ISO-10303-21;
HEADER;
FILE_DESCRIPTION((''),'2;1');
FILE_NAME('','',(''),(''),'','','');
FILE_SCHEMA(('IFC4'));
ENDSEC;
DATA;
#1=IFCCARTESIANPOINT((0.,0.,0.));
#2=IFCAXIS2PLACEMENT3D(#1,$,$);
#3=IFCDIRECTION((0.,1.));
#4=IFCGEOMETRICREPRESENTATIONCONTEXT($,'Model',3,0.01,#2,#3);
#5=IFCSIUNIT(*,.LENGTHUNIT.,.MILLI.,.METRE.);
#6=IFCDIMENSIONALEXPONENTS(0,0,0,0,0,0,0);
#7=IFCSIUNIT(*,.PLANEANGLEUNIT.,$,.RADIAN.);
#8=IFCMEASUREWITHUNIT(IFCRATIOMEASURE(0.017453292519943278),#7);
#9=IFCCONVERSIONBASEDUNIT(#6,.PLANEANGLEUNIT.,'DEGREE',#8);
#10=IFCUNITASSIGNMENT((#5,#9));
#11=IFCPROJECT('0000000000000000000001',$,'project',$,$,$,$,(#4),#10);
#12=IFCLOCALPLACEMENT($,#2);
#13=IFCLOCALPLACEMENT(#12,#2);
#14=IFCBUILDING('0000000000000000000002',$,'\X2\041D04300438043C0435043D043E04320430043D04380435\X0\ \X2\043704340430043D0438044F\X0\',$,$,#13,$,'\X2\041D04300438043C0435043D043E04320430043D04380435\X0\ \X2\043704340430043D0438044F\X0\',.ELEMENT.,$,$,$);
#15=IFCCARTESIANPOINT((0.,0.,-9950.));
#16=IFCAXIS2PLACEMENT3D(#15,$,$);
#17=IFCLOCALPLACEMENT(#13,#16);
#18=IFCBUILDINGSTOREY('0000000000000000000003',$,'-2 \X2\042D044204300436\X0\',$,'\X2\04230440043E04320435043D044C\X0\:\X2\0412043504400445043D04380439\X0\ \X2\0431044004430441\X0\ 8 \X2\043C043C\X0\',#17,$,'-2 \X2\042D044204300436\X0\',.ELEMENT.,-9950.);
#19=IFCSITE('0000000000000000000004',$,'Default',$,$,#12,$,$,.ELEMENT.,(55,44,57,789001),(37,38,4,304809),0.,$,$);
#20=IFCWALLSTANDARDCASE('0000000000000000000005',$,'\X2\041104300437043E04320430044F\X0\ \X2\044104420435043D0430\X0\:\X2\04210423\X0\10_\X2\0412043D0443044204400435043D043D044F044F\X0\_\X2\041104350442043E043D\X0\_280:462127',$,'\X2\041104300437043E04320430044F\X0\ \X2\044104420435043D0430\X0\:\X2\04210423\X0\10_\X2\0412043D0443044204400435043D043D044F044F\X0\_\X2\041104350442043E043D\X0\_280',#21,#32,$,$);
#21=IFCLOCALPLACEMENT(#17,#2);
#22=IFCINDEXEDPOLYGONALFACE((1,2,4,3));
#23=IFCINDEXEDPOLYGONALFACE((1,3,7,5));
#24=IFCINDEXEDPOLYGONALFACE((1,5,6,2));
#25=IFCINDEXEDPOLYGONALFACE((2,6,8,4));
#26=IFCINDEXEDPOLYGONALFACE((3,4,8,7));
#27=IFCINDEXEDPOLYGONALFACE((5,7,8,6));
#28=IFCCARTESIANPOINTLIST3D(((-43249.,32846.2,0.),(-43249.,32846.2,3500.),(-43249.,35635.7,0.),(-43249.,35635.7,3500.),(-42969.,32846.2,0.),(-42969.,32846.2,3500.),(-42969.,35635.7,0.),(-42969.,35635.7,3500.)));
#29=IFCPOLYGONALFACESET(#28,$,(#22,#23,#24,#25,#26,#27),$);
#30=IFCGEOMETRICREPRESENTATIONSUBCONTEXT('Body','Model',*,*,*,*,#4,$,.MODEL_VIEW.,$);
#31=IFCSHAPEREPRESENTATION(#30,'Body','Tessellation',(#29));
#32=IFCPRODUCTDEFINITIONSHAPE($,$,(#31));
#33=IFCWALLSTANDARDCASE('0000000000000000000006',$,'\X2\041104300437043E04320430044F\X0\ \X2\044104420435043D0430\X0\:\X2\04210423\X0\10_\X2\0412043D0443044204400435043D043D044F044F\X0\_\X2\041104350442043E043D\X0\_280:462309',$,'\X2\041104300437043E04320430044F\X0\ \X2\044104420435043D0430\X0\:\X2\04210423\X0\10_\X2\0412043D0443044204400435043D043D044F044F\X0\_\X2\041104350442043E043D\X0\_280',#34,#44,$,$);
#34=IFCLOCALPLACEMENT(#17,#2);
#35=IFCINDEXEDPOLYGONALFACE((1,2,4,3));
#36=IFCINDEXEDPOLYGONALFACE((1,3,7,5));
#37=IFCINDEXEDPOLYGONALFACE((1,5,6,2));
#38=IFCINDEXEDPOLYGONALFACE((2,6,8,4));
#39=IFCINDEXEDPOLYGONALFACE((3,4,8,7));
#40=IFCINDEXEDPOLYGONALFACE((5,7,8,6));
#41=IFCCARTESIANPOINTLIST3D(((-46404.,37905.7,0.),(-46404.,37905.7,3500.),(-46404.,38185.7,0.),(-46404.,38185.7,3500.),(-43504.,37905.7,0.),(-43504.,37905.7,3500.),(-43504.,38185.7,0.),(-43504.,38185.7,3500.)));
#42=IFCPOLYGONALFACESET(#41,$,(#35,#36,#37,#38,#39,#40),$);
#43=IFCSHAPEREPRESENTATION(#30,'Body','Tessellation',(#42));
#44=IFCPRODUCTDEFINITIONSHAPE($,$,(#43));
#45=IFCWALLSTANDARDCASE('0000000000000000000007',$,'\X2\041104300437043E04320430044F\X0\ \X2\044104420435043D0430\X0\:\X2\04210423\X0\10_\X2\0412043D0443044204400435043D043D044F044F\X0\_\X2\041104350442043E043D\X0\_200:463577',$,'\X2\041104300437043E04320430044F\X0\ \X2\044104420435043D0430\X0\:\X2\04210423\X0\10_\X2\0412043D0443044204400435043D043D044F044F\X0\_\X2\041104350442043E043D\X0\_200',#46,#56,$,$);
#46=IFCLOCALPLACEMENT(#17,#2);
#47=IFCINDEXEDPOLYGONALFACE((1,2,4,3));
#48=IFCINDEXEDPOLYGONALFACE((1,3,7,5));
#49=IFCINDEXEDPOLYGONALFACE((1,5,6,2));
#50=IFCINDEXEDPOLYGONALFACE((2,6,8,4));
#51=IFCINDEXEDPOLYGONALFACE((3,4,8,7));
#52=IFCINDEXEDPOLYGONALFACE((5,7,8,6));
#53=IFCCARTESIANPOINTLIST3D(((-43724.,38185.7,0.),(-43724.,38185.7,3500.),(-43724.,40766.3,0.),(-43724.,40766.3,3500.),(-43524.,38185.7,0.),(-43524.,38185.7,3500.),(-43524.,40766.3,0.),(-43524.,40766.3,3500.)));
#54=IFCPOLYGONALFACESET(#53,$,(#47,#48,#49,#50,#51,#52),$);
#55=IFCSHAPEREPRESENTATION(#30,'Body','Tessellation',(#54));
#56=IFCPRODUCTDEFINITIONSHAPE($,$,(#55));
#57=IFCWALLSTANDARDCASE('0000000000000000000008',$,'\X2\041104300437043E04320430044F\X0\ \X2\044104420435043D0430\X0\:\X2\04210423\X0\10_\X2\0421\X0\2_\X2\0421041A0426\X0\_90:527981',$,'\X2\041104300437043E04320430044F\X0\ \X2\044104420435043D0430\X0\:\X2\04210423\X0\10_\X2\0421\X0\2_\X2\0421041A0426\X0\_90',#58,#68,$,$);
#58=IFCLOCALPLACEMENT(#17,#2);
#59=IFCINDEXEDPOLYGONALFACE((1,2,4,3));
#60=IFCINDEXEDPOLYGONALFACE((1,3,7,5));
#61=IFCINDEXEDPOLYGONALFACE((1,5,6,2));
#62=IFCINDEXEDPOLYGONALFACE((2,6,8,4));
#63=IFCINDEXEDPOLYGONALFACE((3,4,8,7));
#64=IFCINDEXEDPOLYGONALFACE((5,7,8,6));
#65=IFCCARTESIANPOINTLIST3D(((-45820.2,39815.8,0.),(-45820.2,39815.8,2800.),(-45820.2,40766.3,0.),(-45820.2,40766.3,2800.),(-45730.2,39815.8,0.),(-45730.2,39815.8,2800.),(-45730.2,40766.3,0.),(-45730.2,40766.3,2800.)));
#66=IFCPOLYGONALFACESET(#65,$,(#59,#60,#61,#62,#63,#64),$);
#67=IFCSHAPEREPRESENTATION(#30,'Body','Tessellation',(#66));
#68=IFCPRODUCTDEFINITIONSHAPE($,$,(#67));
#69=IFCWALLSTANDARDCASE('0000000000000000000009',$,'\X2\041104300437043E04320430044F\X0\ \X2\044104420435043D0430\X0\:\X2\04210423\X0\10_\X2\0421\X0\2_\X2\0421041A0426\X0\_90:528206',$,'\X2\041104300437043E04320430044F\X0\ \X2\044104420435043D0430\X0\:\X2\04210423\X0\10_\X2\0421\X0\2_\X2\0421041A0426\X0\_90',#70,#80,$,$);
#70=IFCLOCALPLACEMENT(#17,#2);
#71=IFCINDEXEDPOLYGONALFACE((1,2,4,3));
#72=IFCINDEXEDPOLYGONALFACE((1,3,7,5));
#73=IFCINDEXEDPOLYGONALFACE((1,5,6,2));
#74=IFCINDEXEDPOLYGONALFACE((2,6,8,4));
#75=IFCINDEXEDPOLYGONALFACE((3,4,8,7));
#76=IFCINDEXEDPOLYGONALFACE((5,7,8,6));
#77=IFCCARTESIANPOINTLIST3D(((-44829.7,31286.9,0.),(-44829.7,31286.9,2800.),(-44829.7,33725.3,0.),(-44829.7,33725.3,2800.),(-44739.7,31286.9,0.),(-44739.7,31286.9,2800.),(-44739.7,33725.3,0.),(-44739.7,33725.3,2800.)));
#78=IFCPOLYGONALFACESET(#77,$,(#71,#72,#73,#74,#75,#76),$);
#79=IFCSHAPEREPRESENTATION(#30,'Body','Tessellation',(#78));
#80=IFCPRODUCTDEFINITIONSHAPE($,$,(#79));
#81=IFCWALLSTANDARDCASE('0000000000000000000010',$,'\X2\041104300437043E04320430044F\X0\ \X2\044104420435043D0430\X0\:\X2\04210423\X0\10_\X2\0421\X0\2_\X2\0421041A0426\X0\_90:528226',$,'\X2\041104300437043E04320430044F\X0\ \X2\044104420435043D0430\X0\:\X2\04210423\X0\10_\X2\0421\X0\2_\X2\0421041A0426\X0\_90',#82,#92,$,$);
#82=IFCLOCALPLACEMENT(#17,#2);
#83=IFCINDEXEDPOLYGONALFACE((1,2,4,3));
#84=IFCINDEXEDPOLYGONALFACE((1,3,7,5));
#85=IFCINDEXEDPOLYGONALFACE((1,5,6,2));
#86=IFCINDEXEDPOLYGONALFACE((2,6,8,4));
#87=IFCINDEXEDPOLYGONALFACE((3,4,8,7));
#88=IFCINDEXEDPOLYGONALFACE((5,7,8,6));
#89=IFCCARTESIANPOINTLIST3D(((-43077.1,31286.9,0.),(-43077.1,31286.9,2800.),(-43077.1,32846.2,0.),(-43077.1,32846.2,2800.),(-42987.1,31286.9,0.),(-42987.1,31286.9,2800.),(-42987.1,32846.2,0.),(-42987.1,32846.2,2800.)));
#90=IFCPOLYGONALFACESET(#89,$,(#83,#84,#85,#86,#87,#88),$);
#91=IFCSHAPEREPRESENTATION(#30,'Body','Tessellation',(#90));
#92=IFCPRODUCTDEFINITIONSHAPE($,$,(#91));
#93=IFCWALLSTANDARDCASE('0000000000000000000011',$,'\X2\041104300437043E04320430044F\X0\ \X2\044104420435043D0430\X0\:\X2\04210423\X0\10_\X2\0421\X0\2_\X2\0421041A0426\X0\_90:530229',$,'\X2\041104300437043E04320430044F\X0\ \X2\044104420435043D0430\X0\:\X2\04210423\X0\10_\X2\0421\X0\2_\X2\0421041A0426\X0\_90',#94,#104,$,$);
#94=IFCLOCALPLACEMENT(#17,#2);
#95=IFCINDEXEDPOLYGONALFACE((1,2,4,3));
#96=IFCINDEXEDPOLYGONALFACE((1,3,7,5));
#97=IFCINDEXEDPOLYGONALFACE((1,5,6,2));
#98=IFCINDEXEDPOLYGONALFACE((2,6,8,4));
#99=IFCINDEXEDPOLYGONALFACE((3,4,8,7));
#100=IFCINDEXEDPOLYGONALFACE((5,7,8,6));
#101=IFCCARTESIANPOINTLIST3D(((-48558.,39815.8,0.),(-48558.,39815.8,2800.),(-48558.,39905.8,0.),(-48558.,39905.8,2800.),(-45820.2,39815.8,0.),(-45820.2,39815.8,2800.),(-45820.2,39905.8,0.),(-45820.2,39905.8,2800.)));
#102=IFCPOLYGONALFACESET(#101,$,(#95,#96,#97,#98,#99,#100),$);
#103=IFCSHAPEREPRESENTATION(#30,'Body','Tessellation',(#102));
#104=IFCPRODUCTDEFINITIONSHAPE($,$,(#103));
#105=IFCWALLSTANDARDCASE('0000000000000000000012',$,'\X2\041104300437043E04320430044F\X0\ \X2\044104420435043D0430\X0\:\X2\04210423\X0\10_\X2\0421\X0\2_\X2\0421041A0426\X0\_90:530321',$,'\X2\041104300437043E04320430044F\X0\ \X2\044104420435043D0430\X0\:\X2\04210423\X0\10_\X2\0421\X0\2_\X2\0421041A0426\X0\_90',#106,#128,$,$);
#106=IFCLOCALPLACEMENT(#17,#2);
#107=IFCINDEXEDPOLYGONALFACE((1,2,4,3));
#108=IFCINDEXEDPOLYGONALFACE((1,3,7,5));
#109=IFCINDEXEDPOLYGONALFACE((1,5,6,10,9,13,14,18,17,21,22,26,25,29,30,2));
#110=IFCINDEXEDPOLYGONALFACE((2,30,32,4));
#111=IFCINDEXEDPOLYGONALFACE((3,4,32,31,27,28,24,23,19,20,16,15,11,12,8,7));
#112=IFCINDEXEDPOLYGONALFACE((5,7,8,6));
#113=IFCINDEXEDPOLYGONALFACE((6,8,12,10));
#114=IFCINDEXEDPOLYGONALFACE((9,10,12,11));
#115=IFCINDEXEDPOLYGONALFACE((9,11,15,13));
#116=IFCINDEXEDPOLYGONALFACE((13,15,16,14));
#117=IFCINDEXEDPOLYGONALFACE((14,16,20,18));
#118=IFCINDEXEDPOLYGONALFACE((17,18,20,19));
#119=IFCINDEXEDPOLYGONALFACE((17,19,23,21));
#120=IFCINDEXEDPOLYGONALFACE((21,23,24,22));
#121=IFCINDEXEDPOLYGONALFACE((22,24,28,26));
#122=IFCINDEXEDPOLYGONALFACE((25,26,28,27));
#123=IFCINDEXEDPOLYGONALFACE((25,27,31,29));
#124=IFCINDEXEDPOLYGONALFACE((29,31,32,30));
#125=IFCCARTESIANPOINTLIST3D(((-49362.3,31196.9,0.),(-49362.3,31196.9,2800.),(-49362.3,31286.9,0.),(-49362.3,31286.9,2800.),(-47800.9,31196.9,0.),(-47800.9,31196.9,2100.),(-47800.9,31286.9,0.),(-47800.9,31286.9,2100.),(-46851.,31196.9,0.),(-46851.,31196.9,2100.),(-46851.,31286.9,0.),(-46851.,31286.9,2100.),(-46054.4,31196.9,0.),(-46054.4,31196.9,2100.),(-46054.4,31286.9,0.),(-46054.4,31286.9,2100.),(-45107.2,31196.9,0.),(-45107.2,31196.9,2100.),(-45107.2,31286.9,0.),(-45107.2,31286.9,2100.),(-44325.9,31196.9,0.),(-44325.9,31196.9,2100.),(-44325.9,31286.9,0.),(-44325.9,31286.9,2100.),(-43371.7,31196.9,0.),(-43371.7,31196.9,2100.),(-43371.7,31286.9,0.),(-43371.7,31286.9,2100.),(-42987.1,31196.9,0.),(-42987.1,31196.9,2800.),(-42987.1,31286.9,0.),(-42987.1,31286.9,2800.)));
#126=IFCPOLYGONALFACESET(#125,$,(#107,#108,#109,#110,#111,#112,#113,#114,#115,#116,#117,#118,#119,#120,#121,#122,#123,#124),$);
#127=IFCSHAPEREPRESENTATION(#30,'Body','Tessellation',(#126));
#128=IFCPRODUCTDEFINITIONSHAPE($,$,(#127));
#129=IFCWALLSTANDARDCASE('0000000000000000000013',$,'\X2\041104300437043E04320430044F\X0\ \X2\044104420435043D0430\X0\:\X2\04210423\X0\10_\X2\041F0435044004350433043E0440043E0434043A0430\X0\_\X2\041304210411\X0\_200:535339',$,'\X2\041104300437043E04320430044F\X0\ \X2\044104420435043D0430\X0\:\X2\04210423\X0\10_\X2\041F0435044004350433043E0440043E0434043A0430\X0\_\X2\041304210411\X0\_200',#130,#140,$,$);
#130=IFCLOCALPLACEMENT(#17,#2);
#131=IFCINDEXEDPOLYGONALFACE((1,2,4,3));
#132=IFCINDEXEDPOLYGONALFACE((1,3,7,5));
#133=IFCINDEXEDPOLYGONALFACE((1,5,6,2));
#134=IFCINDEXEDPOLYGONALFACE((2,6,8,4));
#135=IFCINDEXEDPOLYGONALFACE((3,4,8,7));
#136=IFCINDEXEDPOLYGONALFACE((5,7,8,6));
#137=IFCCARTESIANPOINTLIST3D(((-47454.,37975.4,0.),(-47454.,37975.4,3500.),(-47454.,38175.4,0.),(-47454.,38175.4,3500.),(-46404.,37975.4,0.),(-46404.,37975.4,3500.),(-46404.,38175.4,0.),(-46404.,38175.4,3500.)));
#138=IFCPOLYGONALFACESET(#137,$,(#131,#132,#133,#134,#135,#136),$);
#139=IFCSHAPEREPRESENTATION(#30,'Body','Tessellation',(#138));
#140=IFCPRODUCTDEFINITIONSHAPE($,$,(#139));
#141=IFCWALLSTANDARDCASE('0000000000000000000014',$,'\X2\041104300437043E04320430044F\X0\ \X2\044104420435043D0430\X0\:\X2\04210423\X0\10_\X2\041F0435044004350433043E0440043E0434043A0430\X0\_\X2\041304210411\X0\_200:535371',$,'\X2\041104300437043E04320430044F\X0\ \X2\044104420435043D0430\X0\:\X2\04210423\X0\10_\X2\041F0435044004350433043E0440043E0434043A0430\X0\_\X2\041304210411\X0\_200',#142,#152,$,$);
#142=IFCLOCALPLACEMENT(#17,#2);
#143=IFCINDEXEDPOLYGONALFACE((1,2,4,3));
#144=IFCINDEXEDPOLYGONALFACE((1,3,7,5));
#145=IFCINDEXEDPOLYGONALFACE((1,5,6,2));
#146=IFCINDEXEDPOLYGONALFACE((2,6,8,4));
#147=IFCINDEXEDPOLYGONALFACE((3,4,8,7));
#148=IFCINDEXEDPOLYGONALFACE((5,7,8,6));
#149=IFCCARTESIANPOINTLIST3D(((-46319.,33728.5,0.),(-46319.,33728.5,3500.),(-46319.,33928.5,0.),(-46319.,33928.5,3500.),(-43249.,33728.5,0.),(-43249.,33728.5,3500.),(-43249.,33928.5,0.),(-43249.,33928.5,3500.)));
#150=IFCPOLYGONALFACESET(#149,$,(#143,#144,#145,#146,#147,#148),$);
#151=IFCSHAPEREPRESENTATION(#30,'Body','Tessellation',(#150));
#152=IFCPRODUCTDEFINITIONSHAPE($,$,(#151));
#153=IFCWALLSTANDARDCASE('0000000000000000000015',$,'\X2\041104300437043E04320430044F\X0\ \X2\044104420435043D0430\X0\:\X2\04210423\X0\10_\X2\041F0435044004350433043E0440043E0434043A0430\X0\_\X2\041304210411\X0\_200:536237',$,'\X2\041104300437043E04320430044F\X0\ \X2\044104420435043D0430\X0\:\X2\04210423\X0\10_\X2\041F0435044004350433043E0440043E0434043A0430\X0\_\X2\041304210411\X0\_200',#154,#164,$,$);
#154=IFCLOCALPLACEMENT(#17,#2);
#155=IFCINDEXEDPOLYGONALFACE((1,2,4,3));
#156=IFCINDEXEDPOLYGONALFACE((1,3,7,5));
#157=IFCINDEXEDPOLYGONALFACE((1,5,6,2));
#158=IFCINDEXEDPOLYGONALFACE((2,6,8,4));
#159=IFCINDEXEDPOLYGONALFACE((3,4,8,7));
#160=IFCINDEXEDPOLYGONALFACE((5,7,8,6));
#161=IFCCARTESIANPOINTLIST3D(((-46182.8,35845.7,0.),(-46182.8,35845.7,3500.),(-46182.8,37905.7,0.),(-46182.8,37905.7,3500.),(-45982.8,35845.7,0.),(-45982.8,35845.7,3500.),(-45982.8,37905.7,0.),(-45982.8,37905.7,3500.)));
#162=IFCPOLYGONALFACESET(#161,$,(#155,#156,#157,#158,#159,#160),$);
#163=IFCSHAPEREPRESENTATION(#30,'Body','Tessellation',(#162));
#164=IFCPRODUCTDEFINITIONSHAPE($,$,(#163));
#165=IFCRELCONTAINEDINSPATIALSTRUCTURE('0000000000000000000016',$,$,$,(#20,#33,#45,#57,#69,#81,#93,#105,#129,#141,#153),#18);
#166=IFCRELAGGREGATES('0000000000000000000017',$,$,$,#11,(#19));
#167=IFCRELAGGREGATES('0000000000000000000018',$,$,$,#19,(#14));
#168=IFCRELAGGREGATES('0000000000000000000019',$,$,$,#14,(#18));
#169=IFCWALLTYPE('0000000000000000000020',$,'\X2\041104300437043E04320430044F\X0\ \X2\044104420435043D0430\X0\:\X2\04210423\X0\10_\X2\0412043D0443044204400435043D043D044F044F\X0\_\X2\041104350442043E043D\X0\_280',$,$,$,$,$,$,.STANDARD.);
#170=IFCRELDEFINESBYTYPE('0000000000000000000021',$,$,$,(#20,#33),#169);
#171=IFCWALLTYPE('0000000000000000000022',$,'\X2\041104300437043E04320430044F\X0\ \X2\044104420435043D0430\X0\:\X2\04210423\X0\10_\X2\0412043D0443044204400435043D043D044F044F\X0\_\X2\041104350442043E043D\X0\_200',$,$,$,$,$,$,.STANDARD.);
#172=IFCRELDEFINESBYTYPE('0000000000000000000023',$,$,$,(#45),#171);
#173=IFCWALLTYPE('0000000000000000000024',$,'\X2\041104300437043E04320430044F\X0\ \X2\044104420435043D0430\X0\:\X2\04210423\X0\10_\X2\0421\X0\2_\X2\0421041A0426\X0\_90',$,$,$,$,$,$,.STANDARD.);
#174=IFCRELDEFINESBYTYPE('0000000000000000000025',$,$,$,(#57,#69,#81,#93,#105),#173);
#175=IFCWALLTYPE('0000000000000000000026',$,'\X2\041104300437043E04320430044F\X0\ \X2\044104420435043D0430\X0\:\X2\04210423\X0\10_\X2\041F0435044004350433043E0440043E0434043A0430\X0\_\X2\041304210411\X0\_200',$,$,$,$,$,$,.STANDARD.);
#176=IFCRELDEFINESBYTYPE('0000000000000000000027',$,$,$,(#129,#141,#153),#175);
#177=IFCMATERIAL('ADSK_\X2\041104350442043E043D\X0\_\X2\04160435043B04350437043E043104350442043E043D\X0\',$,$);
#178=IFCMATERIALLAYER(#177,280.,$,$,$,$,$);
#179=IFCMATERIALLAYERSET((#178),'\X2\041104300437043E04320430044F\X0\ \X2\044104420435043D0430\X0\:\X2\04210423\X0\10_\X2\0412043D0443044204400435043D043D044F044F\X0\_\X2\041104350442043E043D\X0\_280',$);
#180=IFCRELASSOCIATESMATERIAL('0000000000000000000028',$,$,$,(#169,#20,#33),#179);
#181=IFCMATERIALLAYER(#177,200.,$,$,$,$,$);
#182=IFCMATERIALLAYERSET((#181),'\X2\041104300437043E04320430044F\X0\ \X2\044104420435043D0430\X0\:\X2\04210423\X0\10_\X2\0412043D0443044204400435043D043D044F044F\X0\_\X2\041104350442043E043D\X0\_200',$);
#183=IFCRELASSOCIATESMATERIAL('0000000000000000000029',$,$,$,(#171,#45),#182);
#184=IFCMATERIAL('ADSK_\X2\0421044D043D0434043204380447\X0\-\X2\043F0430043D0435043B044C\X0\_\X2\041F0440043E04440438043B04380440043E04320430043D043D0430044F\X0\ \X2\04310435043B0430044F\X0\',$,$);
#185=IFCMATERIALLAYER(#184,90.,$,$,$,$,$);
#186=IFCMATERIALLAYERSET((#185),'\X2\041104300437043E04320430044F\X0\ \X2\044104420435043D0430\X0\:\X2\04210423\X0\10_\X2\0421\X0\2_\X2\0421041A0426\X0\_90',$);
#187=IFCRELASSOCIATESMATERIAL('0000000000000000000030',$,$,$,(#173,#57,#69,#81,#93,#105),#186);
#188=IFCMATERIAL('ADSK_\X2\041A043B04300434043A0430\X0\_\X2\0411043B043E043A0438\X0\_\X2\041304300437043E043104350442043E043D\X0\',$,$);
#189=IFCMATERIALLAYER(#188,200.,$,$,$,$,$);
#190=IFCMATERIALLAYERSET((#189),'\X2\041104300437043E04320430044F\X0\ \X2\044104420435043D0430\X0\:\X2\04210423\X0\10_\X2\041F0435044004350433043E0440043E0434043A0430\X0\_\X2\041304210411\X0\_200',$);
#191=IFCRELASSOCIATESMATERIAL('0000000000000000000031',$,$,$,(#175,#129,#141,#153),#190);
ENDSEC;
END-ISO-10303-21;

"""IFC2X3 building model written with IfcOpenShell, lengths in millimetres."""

from ifc_helpers import new_model, entity, si_unit, converted_unit, direction, frame, frame_2d, origin, place, context, subcontext, project, spatial, rectangle, extrude, material, layer, layer_set, layer_usage, type_object, element, save


model = new_model("IFC2X3")

# Units and contexts
model_context = context("Model", 3, precision=0.01, world=origin(), true_north=direction((0.0, 1.0)))
body_context = subcontext(model_context, "Body", "Model", "MODEL_VIEW")
ifc_project = project(units=[si_unit("LENGTHUNIT", "METRE", prefix="MILLI"), converted_unit("PLANEANGLEUNIT", "DEGREE", entity("IfcRatioMeasure", 0.017453292519943278), si_unit("PLANEANGLEUNIT", "RADIAN"), dimensions=[0, 0, 0, 0, 0, 0, 0])], contexts=[model_context])

# Site, building, storey
site_placement = place(None, origin())
site = spatial("IfcSite", under=ifc_project, at=site_placement, Name="Default", CompositionType="ELEMENT", RefLatitude=(55, 44, 57, 789001), RefLongitude=(37, 38, 4, 304809), RefElevation=0.0)
building_placement = place(site_placement, origin())
building = spatial("IfcBuilding", under=site, at=building_placement, Name="Наименование здания", LongName="Наименование здания", CompositionType="ELEMENT")
storey_placement = place(building_placement, frame((0.0, 0.0, -9950.0)))
storey = spatial("IfcBuildingStorey", under=building, at=storey_placement, Name="-2 Этаж", ObjectType="Уровень:Верхний брус 8 мм", LongName="-2 Этаж", CompositionType="ELEMENT", Elevation=-9950.0)

# Walls
ifc_material_1 = material(Name="ADSK_Бетон_Железобетон")
ifc_layer_1 = layer(ifc_material_1, 280.0)
ifc_layer_set_1 = layer_set([ifc_layer_1], Name="Базовая стена:СУ10_Внутренняя_Бетон_280")
ifc_layer_usage_1 = layer_usage(ifc_layer_set_1, "AXIS2", "NEGATIVE", 140.0)
wall_type_1 = type_object("IfcWallType", Name="Базовая стена:СУ10_Внутренняя_Бетон_280", PredefinedType="STANDARD", material=ifc_layer_set_1)
wall_1_placement = place(storey_placement, frame((-43109.0, 35635.7, 0.0), z_axis=(0.0, 0.0, 1.0), x_axis=(0.0, -1.0, 0.0)))
element("IfcWallStandardCase", 1, at=wall_1_placement, inside=storey, type_object=wall_type_1, material=ifc_layer_usage_1, Name="Базовая стена:СУ10_Внутренняя_Бетон_280:462127", ObjectType="Базовая стена:СУ10_Внутренняя_Бетон_280", context=body_context, shape_type="SweptSolid", body=[
    extrude(rectangle(XDim=2789.5, YDim=280.0, at=frame_2d((1394.8, 0.0), x_axis=(-1.0, 0.0))), origin(), (0.0, 0.0, 1.0), 3500.0),
])
wall_2_placement = place(storey_placement, frame((-43504.0, 38045.7, 0.0), z_axis=(0.0, 0.0, 1.0), x_axis=(-1.0, 0.0, 0.0)))
element("IfcWallStandardCase", 2, at=wall_2_placement, inside=storey, type_object=wall_type_1, material=ifc_layer_usage_1, Name="Базовая стена:СУ10_Внутренняя_Бетон_280:462309", ObjectType="Базовая стена:СУ10_Внутренняя_Бетон_280", context=body_context, shape_type="SweptSolid", body=[
    extrude(rectangle(XDim=2900.1, YDim=280.0, at=frame_2d((1450.0, 0.0), x_axis=(-1.0, 0.0))), origin(), (0.0, 0.0, 1.0), 3500.0),
])
ifc_layer_2 = layer(ifc_material_1, 200.0)
ifc_layer_set_2 = layer_set([ifc_layer_2], Name="Базовая стена:СУ10_Внутренняя_Бетон_200")
ifc_layer_usage_2 = layer_usage(ifc_layer_set_2, "AXIS2", "NEGATIVE", 100.0)
wall_type_2 = type_object("IfcWallType", Name="Базовая стена:СУ10_Внутренняя_Бетон_200", PredefinedType="STANDARD", material=ifc_layer_set_2)
wall_3_placement = place(storey_placement, frame((-43624.0, 40766.3, 0.0), z_axis=(0.0, 0.0, 1.0), x_axis=(0.0, -1.0, 0.0)))
element("IfcWallStandardCase", 3, at=wall_3_placement, inside=storey, type_object=wall_type_2, material=ifc_layer_usage_2, Name="Базовая стена:СУ10_Внутренняя_Бетон_200:463577", ObjectType="Базовая стена:СУ10_Внутренняя_Бетон_200", context=body_context, shape_type="SweptSolid", body=[
    extrude(rectangle(XDim=2580.6, YDim=200.0, at=frame_2d((1290.3, 0.0), x_axis=(-1.0, 0.0))), origin(), (0.0, 0.0, 1.0), 3500.0),
])
ifc_material_2 = material(Name="ADSK_Сэндвич-панель_Профилированная белая")
ifc_layer_3 = layer(ifc_material_2, 90.0)
ifc_layer_set_3 = layer_set([ifc_layer_3], Name="Базовая стена:СУ10_С2_СКЦ_90")
ifc_layer_usage_3 = layer_usage(ifc_layer_set_3, "AXIS2", "NEGATIVE", 45.0)
wall_type_3 = type_object("IfcWallType", Name="Базовая стена:СУ10_С2_СКЦ_90", PredefinedType="STANDARD", material=ifc_layer_set_3)
wall_4_placement = place(storey_placement, frame((-45775.2, 40766.3, 0.0), z_axis=(0.0, 0.0, 1.0), x_axis=(0.0, -1.0, 0.0)))
element("IfcWallStandardCase", 4, at=wall_4_placement, inside=storey, type_object=wall_type_3, material=ifc_layer_usage_3, Name="Базовая стена:СУ10_С2_СКЦ_90:527981", ObjectType="Базовая стена:СУ10_С2_СКЦ_90", context=body_context, shape_type="SweptSolid", body=[
    extrude(rectangle(XDim=950.5, YDim=90.0, at=frame_2d((475.3, 0.0), x_axis=(-1.0, 0.0))), origin(), (0.0, 0.0, 1.0), 2800.0),
])
wall_5_placement = place(storey_placement, frame((-44784.7, 33725.3, 0.0), z_axis=(0.0, 0.0, 1.0), x_axis=(0.0, -1.0, 0.0)))
element("IfcWallStandardCase", 5, at=wall_5_placement, inside=storey, type_object=wall_type_3, material=ifc_layer_usage_3, Name="Базовая стена:СУ10_С2_СКЦ_90:528206", ObjectType="Базовая стена:СУ10_С2_СКЦ_90", context=body_context, shape_type="SweptSolid", body=[
    extrude(rectangle(XDim=2438.3, YDim=90.0, at=frame_2d((1219.2, 0.0), x_axis=(-1.0, 0.0))), origin(), (0.0, 0.0, 1.0), 2800.0),
])
wall_6_placement = place(storey_placement, frame((-43032.1, 32846.2, 0.0), z_axis=(0.0, 0.0, 1.0), x_axis=(0.0, -1.0, 0.0)))
element("IfcWallStandardCase", 6, at=wall_6_placement, inside=storey, type_object=wall_type_3, material=ifc_layer_usage_3, Name="Базовая стена:СУ10_С2_СКЦ_90:528226", ObjectType="Базовая стена:СУ10_С2_СКЦ_90", context=body_context, shape_type="SweptSolid", body=[
    extrude(rectangle(XDim=1559.3, YDim=90.0, at=frame_2d((779.6, 0.0), x_axis=(-1.0, 0.0))), origin(), (0.0, 0.0, 1.0), 2800.0),
])
wall_7_placement = place(storey_placement, frame((-45820.2, 39860.8, 0.0), z_axis=(0.0, 0.0, 1.0), x_axis=(-1.0, 0.0, 0.0)))
element("IfcWallStandardCase", 7, at=wall_7_placement, inside=storey, type_object=wall_type_3, material=ifc_layer_usage_3, Name="Базовая стена:СУ10_С2_СКЦ_90:530229", ObjectType="Базовая стена:СУ10_С2_СКЦ_90", context=body_context, shape_type="SweptSolid", body=[
    extrude(rectangle(XDim=2737.8, YDim=90.0, at=frame_2d((1368.9, 0.0), x_axis=(-1.0, 0.0))), origin(), (0.0, 0.0, 1.0), 2800.0),
])

# Wall, openings
wall_8_placement = place(storey_placement, frame((-42987.1, 31241.9, 0.0), z_axis=(0.0, 0.0, 1.0), x_axis=(-1.0, 0.0, 0.0)))
wall_8 = element("IfcWallStandardCase", 8, at=wall_8_placement, inside=storey, type_object=wall_type_3, material=ifc_layer_usage_3, Name="Базовая стена:СУ10_С2_СКЦ_90:530321", ObjectType="Базовая стена:СУ10_С2_СКЦ_90", context=body_context, shape_type="SweptSolid", body=[
    extrude(rectangle(XDim=6375.2, YDim=90.0, at=frame_2d((3187.6, 0.0), x_axis=(1.0, 0.0))), origin(), (0.0, 0.0, 1.0), 2800.0),
])
opening_1_placement = place(wall_8_placement, origin())
element("IfcOpeningElement", 9, at=opening_1_placement, cuts=wall_8, ObjectType="Opening", context=body_context, shape_type="SweptSolid", body=[
    extrude(rectangle(XDim=2100.0, YDim=950.0, at=frame_2d((0.0, 0.0), x_axis=(1.0, 0.0))), frame((4338.8, -45.0, 1050.0), z_axis=(0.0, 1.0, 0.0), x_axis=(0.0, 0.0, -1.0)), (0.0, 0.0, 1.0), 90.0),
])
opening_2_placement = place(wall_8_placement, origin())
element("IfcOpeningElement", 10, at=opening_2_placement, cuts=wall_8, ObjectType="Opening", context=body_context, shape_type="SweptSolid", body=[
    extrude(rectangle(XDim=2100.0, YDim=947.3, at=frame_2d((0.0, 0.0), x_axis=(1.0, 0.0))), frame((2593.7, -45.0, 1050.0), z_axis=(0.0, 1.0, 0.0), x_axis=(0.0, 0.0, -1.0)), (0.0, 0.0, 1.0), 90.0),
])
opening_3_placement = place(wall_8_placement, origin())
element("IfcOpeningElement", 11, at=opening_3_placement, cuts=wall_8, ObjectType="Opening", context=body_context, shape_type="SweptSolid", body=[
    extrude(rectangle(XDim=2100.0, YDim=954.2, at=frame_2d((0.0, 0.0), x_axis=(1.0, 0.0))), frame((861.6, -45.0, 1050.0), z_axis=(0.0, 1.0, 0.0), x_axis=(0.0, 0.0, -1.0)), (0.0, 0.0, 1.0), 90.0),
])

# Walls
ifc_material_3 = material(Name="ADSK_Кладка_Блоки_Газобетон")
ifc_layer_4 = layer(ifc_material_3, 200.0)
ifc_layer_set_4 = layer_set([ifc_layer_4], Name="Базовая стена:СУ10_Перегородка_ГСБ_200")
ifc_layer_usage_4 = layer_usage(ifc_layer_set_4, "AXIS2", "NEGATIVE", 100.0)
wall_type_4 = type_object("IfcWallType", Name="Базовая стена:СУ10_Перегородка_ГСБ_200", PredefinedType="STANDARD", material=ifc_layer_set_4)
wall_9_placement = place(storey_placement, frame((-46404.0, 38075.4, 0.0), z_axis=(0.0, 0.0, 1.0), x_axis=(-1.0, 0.0, 0.0)))
element("IfcWallStandardCase", 12, at=wall_9_placement, inside=storey, type_object=wall_type_4, material=ifc_layer_usage_4, Name="Базовая стена:СУ10_Перегородка_ГСБ_200:535339", ObjectType="Базовая стена:СУ10_Перегородка_ГСБ_200", context=body_context, shape_type="SweptSolid", body=[
    extrude(rectangle(XDim=1049.9, YDim=200.0, at=frame_2d((525.0, 0.0), x_axis=(-1.0, 0.0))), origin(), (0.0, 0.0, 1.0), 3500.0),
])
wall_10_placement = place(storey_placement, frame((-43249.0, 33828.5, 0.0), z_axis=(0.0, 0.0, 1.0), x_axis=(-1.0, 0.0, 0.0)))
element("IfcWallStandardCase", 13, at=wall_10_placement, inside=storey, type_object=wall_type_4, material=ifc_layer_usage_4, Name="Базовая стена:СУ10_Перегородка_ГСБ_200:535371", ObjectType="Базовая стена:СУ10_Перегородка_ГСБ_200", context=body_context, shape_type="SweptSolid", body=[
    extrude(rectangle(XDim=3070.0, YDim=200.0, at=frame_2d((1535.0, 0.0), x_axis=(-1.0, 0.0))), origin(), (0.0, 0.0, 1.0), 3500.0),
])
wall_11_placement = place(storey_placement, frame((-46082.8, 35845.7, 0.0), z_axis=(0.0, 0.0, 1.0), x_axis=(0.0, 1.0, 0.0)))
element("IfcWallStandardCase", 14, at=wall_11_placement, inside=storey, type_object=wall_type_4, material=ifc_layer_usage_4, Name="Базовая стена:СУ10_Перегородка_ГСБ_200:536237", ObjectType="Базовая стена:СУ10_Перегородка_ГСБ_200", context=body_context, shape_type="SweptSolid", body=[
    extrude(rectangle(XDim=2060.0, YDim=200.0, at=frame_2d((1030.0, 0.0), x_axis=(-1.0, 0.0))), origin(), (0.0, 0.0, 1.0), 3500.0),
])

save(model, "model.ifc")
